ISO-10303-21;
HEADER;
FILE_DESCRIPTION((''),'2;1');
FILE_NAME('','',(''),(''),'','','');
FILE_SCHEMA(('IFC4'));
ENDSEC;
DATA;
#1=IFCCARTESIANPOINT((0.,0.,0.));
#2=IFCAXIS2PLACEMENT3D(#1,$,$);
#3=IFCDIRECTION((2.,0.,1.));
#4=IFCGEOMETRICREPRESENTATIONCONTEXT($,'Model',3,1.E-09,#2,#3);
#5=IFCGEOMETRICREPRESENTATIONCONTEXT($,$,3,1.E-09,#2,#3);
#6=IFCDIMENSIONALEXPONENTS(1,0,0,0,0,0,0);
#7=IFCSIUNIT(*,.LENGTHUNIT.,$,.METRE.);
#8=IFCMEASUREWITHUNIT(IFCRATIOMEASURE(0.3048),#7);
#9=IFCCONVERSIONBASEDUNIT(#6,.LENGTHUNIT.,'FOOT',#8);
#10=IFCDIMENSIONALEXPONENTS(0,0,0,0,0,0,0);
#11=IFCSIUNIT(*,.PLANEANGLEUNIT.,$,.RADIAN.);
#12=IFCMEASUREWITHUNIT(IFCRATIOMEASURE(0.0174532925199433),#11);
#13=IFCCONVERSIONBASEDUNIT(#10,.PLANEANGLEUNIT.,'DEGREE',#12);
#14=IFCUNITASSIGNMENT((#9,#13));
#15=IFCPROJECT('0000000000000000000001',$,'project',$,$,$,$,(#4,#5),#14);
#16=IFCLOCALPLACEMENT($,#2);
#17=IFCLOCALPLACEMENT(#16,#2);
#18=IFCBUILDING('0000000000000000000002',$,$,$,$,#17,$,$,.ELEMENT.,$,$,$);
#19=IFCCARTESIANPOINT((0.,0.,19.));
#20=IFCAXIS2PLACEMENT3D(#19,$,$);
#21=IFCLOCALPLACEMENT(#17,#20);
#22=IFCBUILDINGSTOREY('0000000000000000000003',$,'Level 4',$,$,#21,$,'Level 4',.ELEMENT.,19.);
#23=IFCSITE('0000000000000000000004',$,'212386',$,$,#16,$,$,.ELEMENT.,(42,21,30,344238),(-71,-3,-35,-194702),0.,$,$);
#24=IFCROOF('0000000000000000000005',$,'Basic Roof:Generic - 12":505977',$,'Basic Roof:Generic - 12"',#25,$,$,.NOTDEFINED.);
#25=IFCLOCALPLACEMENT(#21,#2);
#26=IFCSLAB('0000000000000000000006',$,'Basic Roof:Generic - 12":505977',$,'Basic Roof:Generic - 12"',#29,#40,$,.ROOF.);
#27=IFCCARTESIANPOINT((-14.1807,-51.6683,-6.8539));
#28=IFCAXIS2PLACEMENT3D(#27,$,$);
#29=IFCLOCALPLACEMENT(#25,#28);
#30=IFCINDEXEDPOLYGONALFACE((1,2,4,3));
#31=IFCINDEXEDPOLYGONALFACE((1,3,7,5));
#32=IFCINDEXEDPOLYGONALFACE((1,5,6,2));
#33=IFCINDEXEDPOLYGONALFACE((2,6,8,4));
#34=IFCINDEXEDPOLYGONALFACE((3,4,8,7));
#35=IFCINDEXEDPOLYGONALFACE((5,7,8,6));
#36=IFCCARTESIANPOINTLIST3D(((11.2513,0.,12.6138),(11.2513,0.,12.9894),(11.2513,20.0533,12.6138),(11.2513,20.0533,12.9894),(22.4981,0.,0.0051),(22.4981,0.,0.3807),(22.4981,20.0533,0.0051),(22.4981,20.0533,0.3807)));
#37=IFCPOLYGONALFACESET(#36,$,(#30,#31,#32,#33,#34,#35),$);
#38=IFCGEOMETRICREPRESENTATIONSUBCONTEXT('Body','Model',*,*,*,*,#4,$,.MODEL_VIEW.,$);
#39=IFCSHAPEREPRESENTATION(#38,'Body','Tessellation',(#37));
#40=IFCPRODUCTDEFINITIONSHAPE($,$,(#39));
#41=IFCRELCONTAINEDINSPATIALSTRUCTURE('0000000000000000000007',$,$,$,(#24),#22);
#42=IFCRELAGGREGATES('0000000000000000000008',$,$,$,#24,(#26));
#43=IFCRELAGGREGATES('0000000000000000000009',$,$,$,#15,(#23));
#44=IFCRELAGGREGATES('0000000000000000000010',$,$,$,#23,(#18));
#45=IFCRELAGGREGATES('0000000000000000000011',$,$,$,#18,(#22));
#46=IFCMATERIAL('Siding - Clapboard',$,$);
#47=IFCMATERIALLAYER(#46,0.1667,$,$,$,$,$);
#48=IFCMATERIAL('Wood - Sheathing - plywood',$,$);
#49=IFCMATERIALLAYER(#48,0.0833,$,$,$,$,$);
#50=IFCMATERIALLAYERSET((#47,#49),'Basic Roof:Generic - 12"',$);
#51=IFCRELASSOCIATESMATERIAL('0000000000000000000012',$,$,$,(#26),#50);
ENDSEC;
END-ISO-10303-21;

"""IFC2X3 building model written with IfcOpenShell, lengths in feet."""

from ifc_helpers import new_model, entity, si_unit, converted_unit, direction, frame, origin, origin_2d_with_axis, place, context, subcontext, project, spatial, rectangle, extrude, material, layer, layer_set, element, aggregate, save


model = new_model("IFC2X3")

# Units and contexts
model_context = context("Model", 3, precision=1e-09, world=origin(), true_north=direction((2.0, 0.0, 1.0)))
context_of_model = context(None, 3, precision=1e-09, world=origin(), true_north=direction((2.0, 0.0, 1.0)))
body_context = subcontext(model_context, "Body", "Model", "MODEL_VIEW")
ifc_project = project(units=[converted_unit("LENGTHUNIT", "FOOT", entity("IfcRatioMeasure", 0.3048), si_unit("LENGTHUNIT", "METRE"), dimensions=[1, 0, 0, 0, 0, 0, 0]), converted_unit("PLANEANGLEUNIT", "DEGREE", entity("IfcRatioMeasure", 0.0174532925199433), si_unit("PLANEANGLEUNIT", "RADIAN"), dimensions=[0, 0, 0, 0, 0, 0, 0])], contexts=[model_context, context_of_model])

# Site, building, storey
site_placement = place(None, origin())
site = spatial("IfcSite", under=ifc_project, at=site_placement, Name="212386", CompositionType="ELEMENT", RefLatitude=(42, 21, 30, 344238), RefLongitude=(-71, -3, -35, -194702), RefElevation=0.0)
building_placement = place(site_placement, origin())
building = spatial("IfcBuilding", under=site, at=building_placement, CompositionType="ELEMENT")
storey_placement = place(building_placement, frame((0.0, 0.0, 19.0)))
storey = spatial("IfcBuildingStorey", under=building, at=storey_placement, Name="Level 4", LongName="Level 4", CompositionType="ELEMENT", Elevation=19.0)

# Roof, slab
roof_placement = place(storey_placement, origin())
roof = element("IfcRoof", 1, at=roof_placement, inside=storey, Name="Basic Roof:Generic - 12\":505977", ObjectType="Basic Roof:Generic - 12\"", ShapeType="NOTDEFINED")
ifc_material_1 = material(Name="Siding - Clapboard")
ifc_layer_1 = layer(ifc_material_1, 0.1667)
ifc_material_2 = material(Name="Wood - Sheathing - plywood")
ifc_layer_2 = layer(ifc_material_2, 0.0833)
ifc_layer_set = layer_set([ifc_layer_1, ifc_layer_2], Name="Basic Roof:Generic - 12\"")
slab_1_placement = place(roof_placement, frame((-14.1807, -51.6683, -6.8539)))
slab_1 = element("IfcSlab", 2, at=slab_1_placement, material=ifc_layer_set, Name="Basic Roof:Generic - 12\":505977", ObjectType="Basic Roof:Generic - 12\"", PredefinedType="ROOF", context=body_context, shape_type="SweptSolid", body=[
    extrude(rectangle(XDim=16.8958, YDim=20.0533, at=origin_2d_with_axis()), frame((16.8747, 10.0266, 6.3095), z_axis=(0.746262, 0.0, 0.665653), x_axis=(0.665653, 0.0, -0.746262)), (-0.746262, 0.0, 0.665653), 0.3756),
])
aggregate(roof, [slab_1])

save(model, "model.ifc")
